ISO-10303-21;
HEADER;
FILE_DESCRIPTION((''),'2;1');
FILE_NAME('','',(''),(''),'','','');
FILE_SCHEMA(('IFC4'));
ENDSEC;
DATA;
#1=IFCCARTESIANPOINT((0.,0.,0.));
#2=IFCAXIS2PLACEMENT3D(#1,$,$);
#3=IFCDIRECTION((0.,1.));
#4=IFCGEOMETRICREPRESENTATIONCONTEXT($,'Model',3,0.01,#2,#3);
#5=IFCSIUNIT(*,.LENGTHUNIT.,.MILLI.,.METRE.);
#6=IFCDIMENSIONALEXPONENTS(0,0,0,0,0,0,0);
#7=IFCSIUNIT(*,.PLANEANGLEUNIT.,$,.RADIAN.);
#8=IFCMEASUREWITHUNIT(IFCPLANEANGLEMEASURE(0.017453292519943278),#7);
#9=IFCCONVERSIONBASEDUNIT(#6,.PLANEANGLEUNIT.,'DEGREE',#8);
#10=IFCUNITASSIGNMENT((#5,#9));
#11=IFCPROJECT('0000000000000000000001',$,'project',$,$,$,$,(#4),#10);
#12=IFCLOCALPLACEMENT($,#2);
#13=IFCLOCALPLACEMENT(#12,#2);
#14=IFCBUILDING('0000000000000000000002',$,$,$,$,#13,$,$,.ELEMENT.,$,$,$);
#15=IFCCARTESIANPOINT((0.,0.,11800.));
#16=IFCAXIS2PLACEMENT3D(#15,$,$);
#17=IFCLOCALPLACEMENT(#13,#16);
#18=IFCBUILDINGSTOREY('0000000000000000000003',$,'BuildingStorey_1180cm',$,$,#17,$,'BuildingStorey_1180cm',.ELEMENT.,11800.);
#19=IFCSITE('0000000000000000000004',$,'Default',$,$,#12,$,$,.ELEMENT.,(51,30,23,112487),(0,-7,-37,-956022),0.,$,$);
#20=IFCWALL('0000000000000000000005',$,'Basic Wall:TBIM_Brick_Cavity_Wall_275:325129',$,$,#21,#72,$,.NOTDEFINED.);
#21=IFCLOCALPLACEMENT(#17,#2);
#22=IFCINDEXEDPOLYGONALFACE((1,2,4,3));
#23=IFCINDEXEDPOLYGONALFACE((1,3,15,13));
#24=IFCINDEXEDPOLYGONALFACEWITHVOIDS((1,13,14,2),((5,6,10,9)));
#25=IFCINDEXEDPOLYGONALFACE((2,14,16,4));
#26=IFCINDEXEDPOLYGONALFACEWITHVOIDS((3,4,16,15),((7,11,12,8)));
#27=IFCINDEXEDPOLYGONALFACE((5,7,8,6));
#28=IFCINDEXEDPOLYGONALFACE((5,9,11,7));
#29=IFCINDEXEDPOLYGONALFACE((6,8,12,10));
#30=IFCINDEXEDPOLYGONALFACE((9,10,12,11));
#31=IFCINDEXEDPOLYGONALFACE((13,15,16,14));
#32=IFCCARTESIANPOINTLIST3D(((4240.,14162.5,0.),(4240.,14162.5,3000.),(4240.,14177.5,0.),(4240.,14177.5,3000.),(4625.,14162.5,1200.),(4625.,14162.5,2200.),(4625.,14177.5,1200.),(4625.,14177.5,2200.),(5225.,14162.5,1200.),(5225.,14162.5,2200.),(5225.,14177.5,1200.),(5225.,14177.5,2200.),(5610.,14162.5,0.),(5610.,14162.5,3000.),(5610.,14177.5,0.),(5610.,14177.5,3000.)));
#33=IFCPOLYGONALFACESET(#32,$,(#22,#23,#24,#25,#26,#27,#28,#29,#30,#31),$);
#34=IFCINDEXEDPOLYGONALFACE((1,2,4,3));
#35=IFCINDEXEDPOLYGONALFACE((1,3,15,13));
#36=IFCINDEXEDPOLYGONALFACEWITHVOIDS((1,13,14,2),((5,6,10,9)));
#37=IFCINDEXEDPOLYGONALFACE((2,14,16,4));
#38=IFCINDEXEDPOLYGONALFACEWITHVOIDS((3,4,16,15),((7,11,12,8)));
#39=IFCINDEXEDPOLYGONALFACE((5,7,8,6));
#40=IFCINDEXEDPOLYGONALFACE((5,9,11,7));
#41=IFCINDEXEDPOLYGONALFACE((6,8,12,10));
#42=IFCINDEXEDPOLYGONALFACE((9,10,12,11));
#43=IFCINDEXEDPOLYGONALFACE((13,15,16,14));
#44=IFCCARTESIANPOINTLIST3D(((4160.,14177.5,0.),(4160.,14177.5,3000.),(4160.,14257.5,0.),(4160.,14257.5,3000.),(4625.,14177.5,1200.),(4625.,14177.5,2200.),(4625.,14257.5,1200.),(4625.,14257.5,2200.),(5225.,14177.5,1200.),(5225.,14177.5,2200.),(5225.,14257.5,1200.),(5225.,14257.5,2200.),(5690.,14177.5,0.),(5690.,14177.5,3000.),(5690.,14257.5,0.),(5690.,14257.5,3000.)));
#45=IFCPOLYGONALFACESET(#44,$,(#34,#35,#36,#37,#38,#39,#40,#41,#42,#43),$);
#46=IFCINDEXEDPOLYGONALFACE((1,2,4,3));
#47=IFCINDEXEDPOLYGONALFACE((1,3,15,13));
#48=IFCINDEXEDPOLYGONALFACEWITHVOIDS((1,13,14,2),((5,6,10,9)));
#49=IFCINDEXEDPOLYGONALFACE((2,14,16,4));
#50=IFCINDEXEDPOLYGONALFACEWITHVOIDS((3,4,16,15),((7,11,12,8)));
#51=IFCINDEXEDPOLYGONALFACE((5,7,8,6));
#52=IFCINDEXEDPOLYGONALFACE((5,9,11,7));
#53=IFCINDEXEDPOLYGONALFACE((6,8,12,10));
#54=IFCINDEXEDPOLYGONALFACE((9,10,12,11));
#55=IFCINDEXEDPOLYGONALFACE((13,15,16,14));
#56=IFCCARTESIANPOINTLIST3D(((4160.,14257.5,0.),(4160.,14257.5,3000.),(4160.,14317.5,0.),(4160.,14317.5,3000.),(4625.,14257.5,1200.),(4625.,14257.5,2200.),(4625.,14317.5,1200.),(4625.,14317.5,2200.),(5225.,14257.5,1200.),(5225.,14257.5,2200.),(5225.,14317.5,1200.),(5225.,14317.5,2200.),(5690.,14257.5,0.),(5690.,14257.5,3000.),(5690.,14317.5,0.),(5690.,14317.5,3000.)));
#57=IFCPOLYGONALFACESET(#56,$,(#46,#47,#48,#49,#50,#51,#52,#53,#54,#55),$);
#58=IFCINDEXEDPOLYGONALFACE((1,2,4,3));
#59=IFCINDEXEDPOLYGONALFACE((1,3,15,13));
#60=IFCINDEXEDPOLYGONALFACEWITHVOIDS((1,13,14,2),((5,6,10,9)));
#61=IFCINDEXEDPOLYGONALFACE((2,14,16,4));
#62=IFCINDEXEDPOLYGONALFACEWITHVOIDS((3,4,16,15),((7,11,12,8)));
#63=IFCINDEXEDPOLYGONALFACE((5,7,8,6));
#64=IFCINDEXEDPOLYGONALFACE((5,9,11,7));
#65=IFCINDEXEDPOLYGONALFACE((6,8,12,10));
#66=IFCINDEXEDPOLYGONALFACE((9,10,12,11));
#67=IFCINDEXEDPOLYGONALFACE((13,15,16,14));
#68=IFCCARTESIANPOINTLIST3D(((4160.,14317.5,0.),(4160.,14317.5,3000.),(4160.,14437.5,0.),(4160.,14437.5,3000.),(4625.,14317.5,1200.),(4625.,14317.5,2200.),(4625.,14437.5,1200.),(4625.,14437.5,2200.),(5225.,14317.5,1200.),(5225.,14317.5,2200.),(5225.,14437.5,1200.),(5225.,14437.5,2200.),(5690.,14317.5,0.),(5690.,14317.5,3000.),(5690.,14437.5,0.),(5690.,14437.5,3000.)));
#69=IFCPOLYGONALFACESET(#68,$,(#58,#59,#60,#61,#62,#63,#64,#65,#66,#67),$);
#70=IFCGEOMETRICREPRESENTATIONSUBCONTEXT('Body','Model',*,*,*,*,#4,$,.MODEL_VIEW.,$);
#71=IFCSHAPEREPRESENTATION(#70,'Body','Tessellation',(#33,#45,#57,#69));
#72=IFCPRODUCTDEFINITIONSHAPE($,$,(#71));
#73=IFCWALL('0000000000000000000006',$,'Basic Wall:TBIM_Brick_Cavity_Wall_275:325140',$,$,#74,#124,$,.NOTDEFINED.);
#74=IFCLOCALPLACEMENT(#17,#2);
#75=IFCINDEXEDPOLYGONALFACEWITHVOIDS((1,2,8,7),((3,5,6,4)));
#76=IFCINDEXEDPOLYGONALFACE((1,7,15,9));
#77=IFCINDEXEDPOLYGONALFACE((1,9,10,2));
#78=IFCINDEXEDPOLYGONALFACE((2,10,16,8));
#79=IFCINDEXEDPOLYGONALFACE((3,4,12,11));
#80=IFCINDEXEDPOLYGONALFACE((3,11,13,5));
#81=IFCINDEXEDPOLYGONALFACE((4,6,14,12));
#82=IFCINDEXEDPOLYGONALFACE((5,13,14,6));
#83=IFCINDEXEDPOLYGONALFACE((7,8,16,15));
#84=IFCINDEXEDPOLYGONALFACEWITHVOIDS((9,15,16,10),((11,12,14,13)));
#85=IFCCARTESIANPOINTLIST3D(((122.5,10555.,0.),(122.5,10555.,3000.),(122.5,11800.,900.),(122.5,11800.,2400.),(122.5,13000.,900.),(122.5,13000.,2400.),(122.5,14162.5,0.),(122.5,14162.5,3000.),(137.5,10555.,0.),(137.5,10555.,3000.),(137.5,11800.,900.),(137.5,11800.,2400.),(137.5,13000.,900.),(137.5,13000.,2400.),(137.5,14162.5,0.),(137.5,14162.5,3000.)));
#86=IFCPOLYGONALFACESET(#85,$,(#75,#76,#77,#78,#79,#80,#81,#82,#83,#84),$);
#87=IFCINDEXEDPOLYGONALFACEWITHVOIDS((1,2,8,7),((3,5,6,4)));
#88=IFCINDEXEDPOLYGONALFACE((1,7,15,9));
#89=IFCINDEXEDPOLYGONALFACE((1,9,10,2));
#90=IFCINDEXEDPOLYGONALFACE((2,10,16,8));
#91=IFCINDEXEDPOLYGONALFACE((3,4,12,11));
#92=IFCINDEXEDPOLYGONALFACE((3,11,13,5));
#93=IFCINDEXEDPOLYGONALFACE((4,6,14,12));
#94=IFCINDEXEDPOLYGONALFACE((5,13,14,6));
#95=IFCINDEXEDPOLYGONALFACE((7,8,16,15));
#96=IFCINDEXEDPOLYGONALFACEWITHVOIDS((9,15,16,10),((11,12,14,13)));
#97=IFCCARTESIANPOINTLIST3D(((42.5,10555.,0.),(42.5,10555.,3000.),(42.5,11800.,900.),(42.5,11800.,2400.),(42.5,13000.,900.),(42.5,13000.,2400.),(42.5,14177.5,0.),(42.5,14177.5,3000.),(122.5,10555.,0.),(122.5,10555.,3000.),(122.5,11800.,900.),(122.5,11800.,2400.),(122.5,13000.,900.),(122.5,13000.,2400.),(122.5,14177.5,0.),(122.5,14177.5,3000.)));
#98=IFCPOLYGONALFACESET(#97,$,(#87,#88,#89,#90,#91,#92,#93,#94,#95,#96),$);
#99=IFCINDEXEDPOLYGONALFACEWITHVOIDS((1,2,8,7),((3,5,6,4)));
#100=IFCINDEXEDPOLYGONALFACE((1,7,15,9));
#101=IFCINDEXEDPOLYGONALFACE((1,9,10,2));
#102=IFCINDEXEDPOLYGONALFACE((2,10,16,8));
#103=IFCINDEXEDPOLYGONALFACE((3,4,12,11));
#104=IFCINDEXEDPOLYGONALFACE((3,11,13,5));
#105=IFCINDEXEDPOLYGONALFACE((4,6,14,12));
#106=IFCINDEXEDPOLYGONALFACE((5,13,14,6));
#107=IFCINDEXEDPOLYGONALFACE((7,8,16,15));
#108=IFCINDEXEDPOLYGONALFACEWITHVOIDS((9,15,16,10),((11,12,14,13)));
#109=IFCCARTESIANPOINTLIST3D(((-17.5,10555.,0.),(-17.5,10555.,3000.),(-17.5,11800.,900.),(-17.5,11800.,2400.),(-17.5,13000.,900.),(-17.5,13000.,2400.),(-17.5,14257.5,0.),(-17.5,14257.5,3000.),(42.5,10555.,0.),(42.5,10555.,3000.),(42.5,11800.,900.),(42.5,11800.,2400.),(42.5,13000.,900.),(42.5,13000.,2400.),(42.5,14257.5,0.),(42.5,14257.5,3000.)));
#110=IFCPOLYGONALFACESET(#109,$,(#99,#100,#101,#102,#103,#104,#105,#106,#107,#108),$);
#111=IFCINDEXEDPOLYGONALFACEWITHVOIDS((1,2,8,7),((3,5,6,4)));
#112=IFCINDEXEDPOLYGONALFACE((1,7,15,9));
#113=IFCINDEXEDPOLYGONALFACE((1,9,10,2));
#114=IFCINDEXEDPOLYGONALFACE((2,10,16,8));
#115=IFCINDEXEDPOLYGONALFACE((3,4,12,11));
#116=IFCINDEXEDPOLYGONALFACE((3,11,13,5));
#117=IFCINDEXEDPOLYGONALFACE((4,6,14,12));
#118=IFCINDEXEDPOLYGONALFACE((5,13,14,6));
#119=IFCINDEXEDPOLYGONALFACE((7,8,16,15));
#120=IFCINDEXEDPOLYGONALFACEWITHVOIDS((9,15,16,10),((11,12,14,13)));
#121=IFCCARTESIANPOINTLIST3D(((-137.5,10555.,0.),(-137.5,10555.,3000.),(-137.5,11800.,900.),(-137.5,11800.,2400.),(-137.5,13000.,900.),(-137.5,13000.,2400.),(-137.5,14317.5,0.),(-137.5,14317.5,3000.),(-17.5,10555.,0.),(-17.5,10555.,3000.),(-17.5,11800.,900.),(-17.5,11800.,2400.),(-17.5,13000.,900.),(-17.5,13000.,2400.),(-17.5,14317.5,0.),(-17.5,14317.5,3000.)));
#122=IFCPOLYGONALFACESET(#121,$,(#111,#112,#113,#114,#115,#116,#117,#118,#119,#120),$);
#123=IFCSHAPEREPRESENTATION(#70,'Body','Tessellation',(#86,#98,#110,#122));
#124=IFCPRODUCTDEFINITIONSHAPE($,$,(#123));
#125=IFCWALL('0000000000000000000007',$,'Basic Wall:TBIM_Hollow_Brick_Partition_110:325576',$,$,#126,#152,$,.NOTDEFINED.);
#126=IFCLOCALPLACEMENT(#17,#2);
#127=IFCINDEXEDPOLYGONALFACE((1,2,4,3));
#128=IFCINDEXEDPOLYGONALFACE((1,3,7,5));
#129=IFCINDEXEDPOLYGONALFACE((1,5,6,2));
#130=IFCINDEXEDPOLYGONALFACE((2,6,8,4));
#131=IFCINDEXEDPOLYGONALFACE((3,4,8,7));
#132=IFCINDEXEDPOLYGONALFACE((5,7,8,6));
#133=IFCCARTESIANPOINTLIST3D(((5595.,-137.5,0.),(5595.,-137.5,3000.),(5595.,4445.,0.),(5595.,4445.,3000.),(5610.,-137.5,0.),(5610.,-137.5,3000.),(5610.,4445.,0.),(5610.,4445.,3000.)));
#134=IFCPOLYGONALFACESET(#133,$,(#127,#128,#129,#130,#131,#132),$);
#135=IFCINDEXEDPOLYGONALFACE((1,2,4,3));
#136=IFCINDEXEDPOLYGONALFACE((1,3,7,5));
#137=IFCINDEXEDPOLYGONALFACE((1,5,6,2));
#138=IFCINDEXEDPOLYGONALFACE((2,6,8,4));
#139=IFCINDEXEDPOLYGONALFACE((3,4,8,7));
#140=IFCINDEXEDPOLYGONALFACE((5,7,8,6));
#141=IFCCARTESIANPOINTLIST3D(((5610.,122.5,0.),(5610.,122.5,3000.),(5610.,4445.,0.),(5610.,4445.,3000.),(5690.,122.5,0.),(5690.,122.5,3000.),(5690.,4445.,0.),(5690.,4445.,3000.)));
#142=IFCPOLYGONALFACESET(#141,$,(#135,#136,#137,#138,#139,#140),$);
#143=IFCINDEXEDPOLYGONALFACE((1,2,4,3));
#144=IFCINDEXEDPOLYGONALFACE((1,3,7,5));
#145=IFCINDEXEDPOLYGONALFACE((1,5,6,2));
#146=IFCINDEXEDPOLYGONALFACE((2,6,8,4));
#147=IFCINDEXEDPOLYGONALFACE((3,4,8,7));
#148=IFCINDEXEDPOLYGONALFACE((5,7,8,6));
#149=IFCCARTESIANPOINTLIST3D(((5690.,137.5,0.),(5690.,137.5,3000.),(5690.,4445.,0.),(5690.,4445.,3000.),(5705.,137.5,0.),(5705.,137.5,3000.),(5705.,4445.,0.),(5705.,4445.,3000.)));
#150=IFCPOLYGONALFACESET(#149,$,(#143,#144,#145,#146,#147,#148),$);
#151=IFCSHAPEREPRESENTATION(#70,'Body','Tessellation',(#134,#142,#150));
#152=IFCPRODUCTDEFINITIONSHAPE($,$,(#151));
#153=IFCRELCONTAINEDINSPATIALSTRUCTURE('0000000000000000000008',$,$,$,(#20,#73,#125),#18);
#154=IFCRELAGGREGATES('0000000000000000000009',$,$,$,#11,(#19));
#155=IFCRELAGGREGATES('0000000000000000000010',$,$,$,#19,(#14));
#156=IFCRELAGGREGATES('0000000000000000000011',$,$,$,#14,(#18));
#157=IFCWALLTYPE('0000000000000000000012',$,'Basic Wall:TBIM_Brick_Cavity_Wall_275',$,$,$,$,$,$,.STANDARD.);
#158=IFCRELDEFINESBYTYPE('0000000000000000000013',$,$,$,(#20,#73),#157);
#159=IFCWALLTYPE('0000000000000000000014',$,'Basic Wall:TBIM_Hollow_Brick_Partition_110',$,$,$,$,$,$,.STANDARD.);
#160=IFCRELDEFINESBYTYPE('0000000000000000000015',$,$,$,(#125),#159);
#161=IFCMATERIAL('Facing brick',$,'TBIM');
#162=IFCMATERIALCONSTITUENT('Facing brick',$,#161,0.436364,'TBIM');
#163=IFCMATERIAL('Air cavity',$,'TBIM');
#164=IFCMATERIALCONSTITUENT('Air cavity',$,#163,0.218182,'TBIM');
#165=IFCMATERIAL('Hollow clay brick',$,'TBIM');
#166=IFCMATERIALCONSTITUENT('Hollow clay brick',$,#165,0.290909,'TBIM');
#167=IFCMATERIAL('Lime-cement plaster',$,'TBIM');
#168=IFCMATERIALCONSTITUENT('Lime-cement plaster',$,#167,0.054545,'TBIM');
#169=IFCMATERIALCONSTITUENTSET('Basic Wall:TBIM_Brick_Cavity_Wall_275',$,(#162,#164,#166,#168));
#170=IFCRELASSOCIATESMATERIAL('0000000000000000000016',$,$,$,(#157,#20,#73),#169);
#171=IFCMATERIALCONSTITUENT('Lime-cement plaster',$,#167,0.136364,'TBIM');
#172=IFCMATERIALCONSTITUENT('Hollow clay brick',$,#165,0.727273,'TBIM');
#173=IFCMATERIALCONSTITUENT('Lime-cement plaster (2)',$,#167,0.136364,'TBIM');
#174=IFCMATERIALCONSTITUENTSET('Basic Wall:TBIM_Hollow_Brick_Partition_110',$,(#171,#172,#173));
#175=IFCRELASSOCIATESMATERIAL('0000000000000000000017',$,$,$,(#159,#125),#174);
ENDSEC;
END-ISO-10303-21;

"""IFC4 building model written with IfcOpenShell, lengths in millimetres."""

from ifc_helpers import new_model, entity, si_unit, converted_unit, direction, frame, origin, place, context, subcontext, project, spatial, indexed_curve, outline, extrude, material, constituent, constituent_set, type_object, element, save


model = new_model("IFC4")

# Units and contexts
model_context = context("Model", 3, precision=0.01, world=origin(), true_north=direction((0.0, 1.0)))
body_context = subcontext(model_context, "Body", "Model", "MODEL_VIEW")
ifc_project = project(units=[si_unit("LENGTHUNIT", "METRE", prefix="MILLI"), converted_unit("PLANEANGLEUNIT", "DEGREE", entity("IfcPlaneAngleMeasure", 0.017453292519943278), si_unit("PLANEANGLEUNIT", "RADIAN"), dimensions=[0, 0, 0, 0, 0, 0, 0])], contexts=[model_context])

# Site, building, storey
site_placement = place(None, origin())
site = spatial("IfcSite", under=ifc_project, at=site_placement, Name="Default", CompositionType="ELEMENT", RefLatitude=(51, 30, 23, 112487), RefLongitude=(0, -7, -37, -956022), RefElevation=0.0)
building_placement = place(site_placement, origin())
building = spatial("IfcBuilding", under=site, at=building_placement, CompositionType="ELEMENT")
storey_placement = place(building_placement, frame((0.0, 0.0, 11800.0)))
storey = spatial("IfcBuildingStorey", under=building, at=storey_placement, Name="BuildingStorey_1180cm", LongName="BuildingStorey_1180cm", CompositionType="ELEMENT", Elevation=11800.0)

# Shared definitions
ifc_material_1 = material(Name="Lime-cement plaster", Category="TBIM")

# Walls, openings
ifc_material_2 = material(Name="Facing brick", Category="TBIM")
ifc_constituent_1 = constituent(ifc_material_2, Name="Facing brick", Category="TBIM", fraction=0.436364)
ifc_material_3 = material(Name="Air cavity", Category="TBIM")
ifc_constituent_2 = constituent(ifc_material_3, Name="Air cavity", Category="TBIM", fraction=0.218182)
ifc_material_4 = material(Name="Hollow clay brick", Category="TBIM")
ifc_constituent_3 = constituent(ifc_material_4, Name="Hollow clay brick", Category="TBIM", fraction=0.290909)
ifc_constituent_4 = constituent(ifc_material_1, Name="Lime-cement plaster", Category="TBIM", fraction=0.054545)
ifc_constituent_set_1 = constituent_set(constituents=[ifc_constituent_1, ifc_constituent_2, ifc_constituent_3, ifc_constituent_4], Name="Basic Wall:TBIM_Brick_Cavity_Wall_275")
wall_type_1 = type_object("IfcWallType", Name="Basic Wall:TBIM_Brick_Cavity_Wall_275", PredefinedType="STANDARD", material=ifc_constituent_set_1)
wall_1_placement = place(storey_placement, frame((5705.0, 14300.0, 0.0), z_axis=(0.0, 0.0, 1.0), x_axis=(-1.0, 0.0, 0.0)))
wall_1 = element("IfcWall", 1, at=wall_1_placement, inside=storey, type_object=wall_type_1, material=ifc_constituent_set_1, Name="Basic Wall:TBIM_Brick_Cavity_Wall_275:325129", PredefinedType="NOTDEFINED", context=body_context, shape_type="SweptSolid", body=[
    extrude(outline(indexed_curve([(-685.0, -1500.0), (-670.0, -1500.0), (670.0, -1500.0), (685.0, -1500.0), (685.0, 1500.0), (670.0, 1500.0), (-670.0, 1500.0), (-685.0, 1500.0), (-685.0, -1500.0)], self_intersect=False), holes=[indexed_curve([(-300.0, 700.0), (300.0, 700.0), (300.0, -300.0), (-300.0, -300.0), (-300.0, 700.0)], self_intersect=False)]), frame((780.0, 137.5, 1500.0), z_axis=(0.0, -1.0, 0.0), x_axis=(1.0, 0.0, 0.0)), (0.0, 0.0, 1.0), 15.0),
    extrude(outline(indexed_curve([(-1500.0, -765.0), (1500.0, -765.0), (1500.0, 765.0), (-1500.0, 765.0), (-1500.0, -765.0)], self_intersect=False), holes=[indexed_curve([(700.0, 300.0), (700.0, -300.0), (-300.0, -300.0), (-300.0, 300.0), (700.0, 300.0)], self_intersect=False)]), frame((780.0, 122.5, 1500.0), z_axis=(0.0, -1.0, 0.0), x_axis=(0.0, 0.0, 1.0)), (0.0, 0.0, 1.0), 80.0),
    extrude(outline(indexed_curve([(-1500.0, -765.0), (1500.0, -765.0), (1500.0, 765.0), (-1500.0, 765.0), (-1500.0, -765.0)], self_intersect=False), holes=[indexed_curve([(700.0, 300.0), (700.0, -300.0), (-300.0, -300.0), (-300.0, 300.0), (700.0, 300.0)], self_intersect=False)]), frame((780.0, 42.5, 1500.0), z_axis=(0.0, -1.0, 0.0), x_axis=(0.0, 0.0, 1.0)), (0.0, 0.0, 1.0), 60.0),
    extrude(outline(indexed_curve([(-1500.0, -765.0), (1500.0, -765.0), (1500.0, 765.0), (-1500.0, 765.0), (-1500.0, -765.0)], self_intersect=False), holes=[indexed_curve([(700.0, 300.0), (700.0, -300.0), (-300.0, -300.0), (-300.0, 300.0), (700.0, 300.0)], self_intersect=False)]), frame((780.0, -17.5, 1500.0), z_axis=(0.0, -1.0, 0.0), x_axis=(0.0, 0.0, 1.0)), (0.0, 0.0, 1.0), 120.0),
])
opening_1_placement = place(wall_1_placement, frame((480.0, -137.5, 1200.0)))
element("IfcOpeningElement", 2, at=opening_1_placement, cuts=wall_1, PredefinedType="OPENING", context=body_context, shape_type="SweptSolid", body=[
    extrude(outline(indexed_curve([(1000.0, 0.0), (1000.0, 600.0), (0.0, 600.0), (0.0, 0.0), (1000.0, 0.0)], self_intersect=False)), frame((0.0, 0.0, 0.0), z_axis=(0.0, 1.0, 0.0), x_axis=(0.0, 0.0, 1.0)), (0.0, 0.0, 1.0), 275.0),
])
wall_2_placement = place(storey_placement, frame((0.0, 10555.0, 0.0), z_axis=(0.0, 0.0, 1.0), x_axis=(0.0, 1.0, 0.0)))
wall_2 = element("IfcWall", 3, at=wall_2_placement, inside=storey, type_object=wall_type_1, material=ifc_constituent_set_1, Name="Basic Wall:TBIM_Brick_Cavity_Wall_275:325140", PredefinedType="NOTDEFINED", context=body_context, shape_type="SweptSolid", body=[
    extrude(outline(indexed_curve([(-1500.0, -1803.7), (1500.0, -1803.8), (1500.0, 1803.7), (-1500.0, 1803.7), (-1500.0, -1803.7)], self_intersect=False), holes=[indexed_curve([(900.0, 558.8), (900.0, -641.2), (-600.0, -641.2), (-600.0, 558.8), (900.0, 558.8)], self_intersect=False)]), frame((1803.7, -122.5, 1500.0), z_axis=(0.0, -1.0, 0.0), x_axis=(0.0, 0.0, 1.0)), (0.0, 0.0, 1.0), 15.0),
    extrude(outline(indexed_curve([(-1500.0, -1811.2), (1500.0, -1811.2), (1500.0, 1811.2), (-1500.0, 1811.2), (-1500.0, -1811.2)], self_intersect=False), holes=[indexed_curve([(900.0, 566.3), (900.0, -633.7), (-600.0, -633.7), (-600.0, 566.3), (900.0, 566.3)], self_intersect=False)]), frame((1811.2, -42.5, 1500.0), z_axis=(0.0, -1.0, 0.0), x_axis=(0.0, 0.0, 1.0)), (0.0, 0.0, 1.0), 80.0),
    extrude(outline(indexed_curve([(-1500.0, -1851.2), (1500.0, -1851.2), (1500.0, 1851.2), (-1500.0, 1851.2), (-1500.0, -1851.2)], self_intersect=False), holes=[indexed_curve([(900.0, 606.3), (900.0, -593.7), (-600.0, -593.7), (-600.0, 606.3), (900.0, 606.3)], self_intersect=False)]), frame((1851.2, 17.5, 1500.0), z_axis=(0.0, -1.0, 0.0), x_axis=(0.0, 0.0, 1.0)), (0.0, 0.0, 1.0), 60.0),
    extrude(outline(indexed_curve([(-1881.2, -1500.0), (1881.2, -1500.0), (1881.2, 1500.0), (-1881.2, 1500.0), (-1881.2, -1500.0)], self_intersect=False), holes=[indexed_curve([(-636.3, 900.0), (563.7, 900.0), (563.7, -600.0), (-636.3, -600.0), (-636.3, 900.0)], self_intersect=False)]), frame((1881.2, 137.5, 1500.0), z_axis=(0.0, -1.0, 0.0), x_axis=(1.0, 0.0, 0.0)), (0.0, 0.0, 1.0), 120.0),
])
opening_2_placement = place(wall_2_placement, frame((1245.0, -137.5, 900.0)))
element("IfcOpeningElement", 4, at=opening_2_placement, cuts=wall_2, PredefinedType="OPENING", context=body_context, shape_type="SweptSolid", body=[
    extrude(outline(indexed_curve([(1500.0, 0.0), (1500.0, 1200.0), (0.0, 1200.0), (0.0, 0.0), (1500.0, 0.0)], self_intersect=False)), frame((0.0, 0.0, 0.0), z_axis=(0.0, 1.0, 0.0), x_axis=(0.0, 0.0, 1.0)), (0.0, 0.0, 1.0), 275.0),
])

# Wall
ifc_constituent_5 = constituent(ifc_material_1, Name="Lime-cement plaster", Category="TBIM", fraction=0.136364)
ifc_constituent_6 = constituent(ifc_material_4, Name="Hollow clay brick", Category="TBIM", fraction=0.727273)
ifc_constituent_7 = constituent(ifc_material_1, Name="Lime-cement plaster (2)", Category="TBIM", fraction=0.136364)
ifc_constituent_set_2 = constituent_set(constituents=[ifc_constituent_5, ifc_constituent_6, ifc_constituent_7], Name="Basic Wall:TBIM_Hollow_Brick_Partition_110")
wall_type_2 = type_object("IfcWallType", Name="Basic Wall:TBIM_Hollow_Brick_Partition_110", PredefinedType="STANDARD", material=ifc_constituent_set_2)
wall_3_placement = place(storey_placement, frame((5650.0, 137.5, 0.0), z_axis=(0.0, 0.0, 1.0), x_axis=(0.0, 1.0, 0.0)))
element("IfcWall", 5, at=wall_3_placement, inside=storey, type_object=wall_type_2, material=ifc_constituent_set_2, Name="Basic Wall:TBIM_Hollow_Brick_Partition_110:325576", PredefinedType="NOTDEFINED", context=body_context, shape_type="SweptSolid", body=[
    extrude(outline(indexed_curve([(-7.5, -2291.2), (7.5, -2291.2), (7.5, 2291.2), (-7.5, 2291.2), (-7.5, -2291.2)], self_intersect=False)), frame((2016.2, 47.5, 0.0), z_axis=(0.0, 0.0, 1.0), x_axis=(0.0, -1.0, 0.0)), (0.0, 0.0, 1.0), 3000.0),
    extrude(outline(indexed_curve([(-2161.2, -40.0), (2161.2, -40.0), (2161.2, 40.0), (-2161.3, 40.0), (-2161.2, -40.0)], self_intersect=False)), frame((2146.2, 0.0, 0.0)), (0.0, 0.0, 1.0), 3000.0),
    extrude(outline(indexed_curve([(-7.5, -2153.8), (7.5, -2153.8), (7.5, 2153.8), (-7.5, 2153.8), (-7.5, -2153.8)], self_intersect=False)), frame((2153.8, -47.5, 0.0), z_axis=(0.0, 0.0, 1.0), x_axis=(0.0, 1.0, 0.0)), (0.0, 0.0, 1.0), 3000.0),
])

save(model, "model.ifc")
